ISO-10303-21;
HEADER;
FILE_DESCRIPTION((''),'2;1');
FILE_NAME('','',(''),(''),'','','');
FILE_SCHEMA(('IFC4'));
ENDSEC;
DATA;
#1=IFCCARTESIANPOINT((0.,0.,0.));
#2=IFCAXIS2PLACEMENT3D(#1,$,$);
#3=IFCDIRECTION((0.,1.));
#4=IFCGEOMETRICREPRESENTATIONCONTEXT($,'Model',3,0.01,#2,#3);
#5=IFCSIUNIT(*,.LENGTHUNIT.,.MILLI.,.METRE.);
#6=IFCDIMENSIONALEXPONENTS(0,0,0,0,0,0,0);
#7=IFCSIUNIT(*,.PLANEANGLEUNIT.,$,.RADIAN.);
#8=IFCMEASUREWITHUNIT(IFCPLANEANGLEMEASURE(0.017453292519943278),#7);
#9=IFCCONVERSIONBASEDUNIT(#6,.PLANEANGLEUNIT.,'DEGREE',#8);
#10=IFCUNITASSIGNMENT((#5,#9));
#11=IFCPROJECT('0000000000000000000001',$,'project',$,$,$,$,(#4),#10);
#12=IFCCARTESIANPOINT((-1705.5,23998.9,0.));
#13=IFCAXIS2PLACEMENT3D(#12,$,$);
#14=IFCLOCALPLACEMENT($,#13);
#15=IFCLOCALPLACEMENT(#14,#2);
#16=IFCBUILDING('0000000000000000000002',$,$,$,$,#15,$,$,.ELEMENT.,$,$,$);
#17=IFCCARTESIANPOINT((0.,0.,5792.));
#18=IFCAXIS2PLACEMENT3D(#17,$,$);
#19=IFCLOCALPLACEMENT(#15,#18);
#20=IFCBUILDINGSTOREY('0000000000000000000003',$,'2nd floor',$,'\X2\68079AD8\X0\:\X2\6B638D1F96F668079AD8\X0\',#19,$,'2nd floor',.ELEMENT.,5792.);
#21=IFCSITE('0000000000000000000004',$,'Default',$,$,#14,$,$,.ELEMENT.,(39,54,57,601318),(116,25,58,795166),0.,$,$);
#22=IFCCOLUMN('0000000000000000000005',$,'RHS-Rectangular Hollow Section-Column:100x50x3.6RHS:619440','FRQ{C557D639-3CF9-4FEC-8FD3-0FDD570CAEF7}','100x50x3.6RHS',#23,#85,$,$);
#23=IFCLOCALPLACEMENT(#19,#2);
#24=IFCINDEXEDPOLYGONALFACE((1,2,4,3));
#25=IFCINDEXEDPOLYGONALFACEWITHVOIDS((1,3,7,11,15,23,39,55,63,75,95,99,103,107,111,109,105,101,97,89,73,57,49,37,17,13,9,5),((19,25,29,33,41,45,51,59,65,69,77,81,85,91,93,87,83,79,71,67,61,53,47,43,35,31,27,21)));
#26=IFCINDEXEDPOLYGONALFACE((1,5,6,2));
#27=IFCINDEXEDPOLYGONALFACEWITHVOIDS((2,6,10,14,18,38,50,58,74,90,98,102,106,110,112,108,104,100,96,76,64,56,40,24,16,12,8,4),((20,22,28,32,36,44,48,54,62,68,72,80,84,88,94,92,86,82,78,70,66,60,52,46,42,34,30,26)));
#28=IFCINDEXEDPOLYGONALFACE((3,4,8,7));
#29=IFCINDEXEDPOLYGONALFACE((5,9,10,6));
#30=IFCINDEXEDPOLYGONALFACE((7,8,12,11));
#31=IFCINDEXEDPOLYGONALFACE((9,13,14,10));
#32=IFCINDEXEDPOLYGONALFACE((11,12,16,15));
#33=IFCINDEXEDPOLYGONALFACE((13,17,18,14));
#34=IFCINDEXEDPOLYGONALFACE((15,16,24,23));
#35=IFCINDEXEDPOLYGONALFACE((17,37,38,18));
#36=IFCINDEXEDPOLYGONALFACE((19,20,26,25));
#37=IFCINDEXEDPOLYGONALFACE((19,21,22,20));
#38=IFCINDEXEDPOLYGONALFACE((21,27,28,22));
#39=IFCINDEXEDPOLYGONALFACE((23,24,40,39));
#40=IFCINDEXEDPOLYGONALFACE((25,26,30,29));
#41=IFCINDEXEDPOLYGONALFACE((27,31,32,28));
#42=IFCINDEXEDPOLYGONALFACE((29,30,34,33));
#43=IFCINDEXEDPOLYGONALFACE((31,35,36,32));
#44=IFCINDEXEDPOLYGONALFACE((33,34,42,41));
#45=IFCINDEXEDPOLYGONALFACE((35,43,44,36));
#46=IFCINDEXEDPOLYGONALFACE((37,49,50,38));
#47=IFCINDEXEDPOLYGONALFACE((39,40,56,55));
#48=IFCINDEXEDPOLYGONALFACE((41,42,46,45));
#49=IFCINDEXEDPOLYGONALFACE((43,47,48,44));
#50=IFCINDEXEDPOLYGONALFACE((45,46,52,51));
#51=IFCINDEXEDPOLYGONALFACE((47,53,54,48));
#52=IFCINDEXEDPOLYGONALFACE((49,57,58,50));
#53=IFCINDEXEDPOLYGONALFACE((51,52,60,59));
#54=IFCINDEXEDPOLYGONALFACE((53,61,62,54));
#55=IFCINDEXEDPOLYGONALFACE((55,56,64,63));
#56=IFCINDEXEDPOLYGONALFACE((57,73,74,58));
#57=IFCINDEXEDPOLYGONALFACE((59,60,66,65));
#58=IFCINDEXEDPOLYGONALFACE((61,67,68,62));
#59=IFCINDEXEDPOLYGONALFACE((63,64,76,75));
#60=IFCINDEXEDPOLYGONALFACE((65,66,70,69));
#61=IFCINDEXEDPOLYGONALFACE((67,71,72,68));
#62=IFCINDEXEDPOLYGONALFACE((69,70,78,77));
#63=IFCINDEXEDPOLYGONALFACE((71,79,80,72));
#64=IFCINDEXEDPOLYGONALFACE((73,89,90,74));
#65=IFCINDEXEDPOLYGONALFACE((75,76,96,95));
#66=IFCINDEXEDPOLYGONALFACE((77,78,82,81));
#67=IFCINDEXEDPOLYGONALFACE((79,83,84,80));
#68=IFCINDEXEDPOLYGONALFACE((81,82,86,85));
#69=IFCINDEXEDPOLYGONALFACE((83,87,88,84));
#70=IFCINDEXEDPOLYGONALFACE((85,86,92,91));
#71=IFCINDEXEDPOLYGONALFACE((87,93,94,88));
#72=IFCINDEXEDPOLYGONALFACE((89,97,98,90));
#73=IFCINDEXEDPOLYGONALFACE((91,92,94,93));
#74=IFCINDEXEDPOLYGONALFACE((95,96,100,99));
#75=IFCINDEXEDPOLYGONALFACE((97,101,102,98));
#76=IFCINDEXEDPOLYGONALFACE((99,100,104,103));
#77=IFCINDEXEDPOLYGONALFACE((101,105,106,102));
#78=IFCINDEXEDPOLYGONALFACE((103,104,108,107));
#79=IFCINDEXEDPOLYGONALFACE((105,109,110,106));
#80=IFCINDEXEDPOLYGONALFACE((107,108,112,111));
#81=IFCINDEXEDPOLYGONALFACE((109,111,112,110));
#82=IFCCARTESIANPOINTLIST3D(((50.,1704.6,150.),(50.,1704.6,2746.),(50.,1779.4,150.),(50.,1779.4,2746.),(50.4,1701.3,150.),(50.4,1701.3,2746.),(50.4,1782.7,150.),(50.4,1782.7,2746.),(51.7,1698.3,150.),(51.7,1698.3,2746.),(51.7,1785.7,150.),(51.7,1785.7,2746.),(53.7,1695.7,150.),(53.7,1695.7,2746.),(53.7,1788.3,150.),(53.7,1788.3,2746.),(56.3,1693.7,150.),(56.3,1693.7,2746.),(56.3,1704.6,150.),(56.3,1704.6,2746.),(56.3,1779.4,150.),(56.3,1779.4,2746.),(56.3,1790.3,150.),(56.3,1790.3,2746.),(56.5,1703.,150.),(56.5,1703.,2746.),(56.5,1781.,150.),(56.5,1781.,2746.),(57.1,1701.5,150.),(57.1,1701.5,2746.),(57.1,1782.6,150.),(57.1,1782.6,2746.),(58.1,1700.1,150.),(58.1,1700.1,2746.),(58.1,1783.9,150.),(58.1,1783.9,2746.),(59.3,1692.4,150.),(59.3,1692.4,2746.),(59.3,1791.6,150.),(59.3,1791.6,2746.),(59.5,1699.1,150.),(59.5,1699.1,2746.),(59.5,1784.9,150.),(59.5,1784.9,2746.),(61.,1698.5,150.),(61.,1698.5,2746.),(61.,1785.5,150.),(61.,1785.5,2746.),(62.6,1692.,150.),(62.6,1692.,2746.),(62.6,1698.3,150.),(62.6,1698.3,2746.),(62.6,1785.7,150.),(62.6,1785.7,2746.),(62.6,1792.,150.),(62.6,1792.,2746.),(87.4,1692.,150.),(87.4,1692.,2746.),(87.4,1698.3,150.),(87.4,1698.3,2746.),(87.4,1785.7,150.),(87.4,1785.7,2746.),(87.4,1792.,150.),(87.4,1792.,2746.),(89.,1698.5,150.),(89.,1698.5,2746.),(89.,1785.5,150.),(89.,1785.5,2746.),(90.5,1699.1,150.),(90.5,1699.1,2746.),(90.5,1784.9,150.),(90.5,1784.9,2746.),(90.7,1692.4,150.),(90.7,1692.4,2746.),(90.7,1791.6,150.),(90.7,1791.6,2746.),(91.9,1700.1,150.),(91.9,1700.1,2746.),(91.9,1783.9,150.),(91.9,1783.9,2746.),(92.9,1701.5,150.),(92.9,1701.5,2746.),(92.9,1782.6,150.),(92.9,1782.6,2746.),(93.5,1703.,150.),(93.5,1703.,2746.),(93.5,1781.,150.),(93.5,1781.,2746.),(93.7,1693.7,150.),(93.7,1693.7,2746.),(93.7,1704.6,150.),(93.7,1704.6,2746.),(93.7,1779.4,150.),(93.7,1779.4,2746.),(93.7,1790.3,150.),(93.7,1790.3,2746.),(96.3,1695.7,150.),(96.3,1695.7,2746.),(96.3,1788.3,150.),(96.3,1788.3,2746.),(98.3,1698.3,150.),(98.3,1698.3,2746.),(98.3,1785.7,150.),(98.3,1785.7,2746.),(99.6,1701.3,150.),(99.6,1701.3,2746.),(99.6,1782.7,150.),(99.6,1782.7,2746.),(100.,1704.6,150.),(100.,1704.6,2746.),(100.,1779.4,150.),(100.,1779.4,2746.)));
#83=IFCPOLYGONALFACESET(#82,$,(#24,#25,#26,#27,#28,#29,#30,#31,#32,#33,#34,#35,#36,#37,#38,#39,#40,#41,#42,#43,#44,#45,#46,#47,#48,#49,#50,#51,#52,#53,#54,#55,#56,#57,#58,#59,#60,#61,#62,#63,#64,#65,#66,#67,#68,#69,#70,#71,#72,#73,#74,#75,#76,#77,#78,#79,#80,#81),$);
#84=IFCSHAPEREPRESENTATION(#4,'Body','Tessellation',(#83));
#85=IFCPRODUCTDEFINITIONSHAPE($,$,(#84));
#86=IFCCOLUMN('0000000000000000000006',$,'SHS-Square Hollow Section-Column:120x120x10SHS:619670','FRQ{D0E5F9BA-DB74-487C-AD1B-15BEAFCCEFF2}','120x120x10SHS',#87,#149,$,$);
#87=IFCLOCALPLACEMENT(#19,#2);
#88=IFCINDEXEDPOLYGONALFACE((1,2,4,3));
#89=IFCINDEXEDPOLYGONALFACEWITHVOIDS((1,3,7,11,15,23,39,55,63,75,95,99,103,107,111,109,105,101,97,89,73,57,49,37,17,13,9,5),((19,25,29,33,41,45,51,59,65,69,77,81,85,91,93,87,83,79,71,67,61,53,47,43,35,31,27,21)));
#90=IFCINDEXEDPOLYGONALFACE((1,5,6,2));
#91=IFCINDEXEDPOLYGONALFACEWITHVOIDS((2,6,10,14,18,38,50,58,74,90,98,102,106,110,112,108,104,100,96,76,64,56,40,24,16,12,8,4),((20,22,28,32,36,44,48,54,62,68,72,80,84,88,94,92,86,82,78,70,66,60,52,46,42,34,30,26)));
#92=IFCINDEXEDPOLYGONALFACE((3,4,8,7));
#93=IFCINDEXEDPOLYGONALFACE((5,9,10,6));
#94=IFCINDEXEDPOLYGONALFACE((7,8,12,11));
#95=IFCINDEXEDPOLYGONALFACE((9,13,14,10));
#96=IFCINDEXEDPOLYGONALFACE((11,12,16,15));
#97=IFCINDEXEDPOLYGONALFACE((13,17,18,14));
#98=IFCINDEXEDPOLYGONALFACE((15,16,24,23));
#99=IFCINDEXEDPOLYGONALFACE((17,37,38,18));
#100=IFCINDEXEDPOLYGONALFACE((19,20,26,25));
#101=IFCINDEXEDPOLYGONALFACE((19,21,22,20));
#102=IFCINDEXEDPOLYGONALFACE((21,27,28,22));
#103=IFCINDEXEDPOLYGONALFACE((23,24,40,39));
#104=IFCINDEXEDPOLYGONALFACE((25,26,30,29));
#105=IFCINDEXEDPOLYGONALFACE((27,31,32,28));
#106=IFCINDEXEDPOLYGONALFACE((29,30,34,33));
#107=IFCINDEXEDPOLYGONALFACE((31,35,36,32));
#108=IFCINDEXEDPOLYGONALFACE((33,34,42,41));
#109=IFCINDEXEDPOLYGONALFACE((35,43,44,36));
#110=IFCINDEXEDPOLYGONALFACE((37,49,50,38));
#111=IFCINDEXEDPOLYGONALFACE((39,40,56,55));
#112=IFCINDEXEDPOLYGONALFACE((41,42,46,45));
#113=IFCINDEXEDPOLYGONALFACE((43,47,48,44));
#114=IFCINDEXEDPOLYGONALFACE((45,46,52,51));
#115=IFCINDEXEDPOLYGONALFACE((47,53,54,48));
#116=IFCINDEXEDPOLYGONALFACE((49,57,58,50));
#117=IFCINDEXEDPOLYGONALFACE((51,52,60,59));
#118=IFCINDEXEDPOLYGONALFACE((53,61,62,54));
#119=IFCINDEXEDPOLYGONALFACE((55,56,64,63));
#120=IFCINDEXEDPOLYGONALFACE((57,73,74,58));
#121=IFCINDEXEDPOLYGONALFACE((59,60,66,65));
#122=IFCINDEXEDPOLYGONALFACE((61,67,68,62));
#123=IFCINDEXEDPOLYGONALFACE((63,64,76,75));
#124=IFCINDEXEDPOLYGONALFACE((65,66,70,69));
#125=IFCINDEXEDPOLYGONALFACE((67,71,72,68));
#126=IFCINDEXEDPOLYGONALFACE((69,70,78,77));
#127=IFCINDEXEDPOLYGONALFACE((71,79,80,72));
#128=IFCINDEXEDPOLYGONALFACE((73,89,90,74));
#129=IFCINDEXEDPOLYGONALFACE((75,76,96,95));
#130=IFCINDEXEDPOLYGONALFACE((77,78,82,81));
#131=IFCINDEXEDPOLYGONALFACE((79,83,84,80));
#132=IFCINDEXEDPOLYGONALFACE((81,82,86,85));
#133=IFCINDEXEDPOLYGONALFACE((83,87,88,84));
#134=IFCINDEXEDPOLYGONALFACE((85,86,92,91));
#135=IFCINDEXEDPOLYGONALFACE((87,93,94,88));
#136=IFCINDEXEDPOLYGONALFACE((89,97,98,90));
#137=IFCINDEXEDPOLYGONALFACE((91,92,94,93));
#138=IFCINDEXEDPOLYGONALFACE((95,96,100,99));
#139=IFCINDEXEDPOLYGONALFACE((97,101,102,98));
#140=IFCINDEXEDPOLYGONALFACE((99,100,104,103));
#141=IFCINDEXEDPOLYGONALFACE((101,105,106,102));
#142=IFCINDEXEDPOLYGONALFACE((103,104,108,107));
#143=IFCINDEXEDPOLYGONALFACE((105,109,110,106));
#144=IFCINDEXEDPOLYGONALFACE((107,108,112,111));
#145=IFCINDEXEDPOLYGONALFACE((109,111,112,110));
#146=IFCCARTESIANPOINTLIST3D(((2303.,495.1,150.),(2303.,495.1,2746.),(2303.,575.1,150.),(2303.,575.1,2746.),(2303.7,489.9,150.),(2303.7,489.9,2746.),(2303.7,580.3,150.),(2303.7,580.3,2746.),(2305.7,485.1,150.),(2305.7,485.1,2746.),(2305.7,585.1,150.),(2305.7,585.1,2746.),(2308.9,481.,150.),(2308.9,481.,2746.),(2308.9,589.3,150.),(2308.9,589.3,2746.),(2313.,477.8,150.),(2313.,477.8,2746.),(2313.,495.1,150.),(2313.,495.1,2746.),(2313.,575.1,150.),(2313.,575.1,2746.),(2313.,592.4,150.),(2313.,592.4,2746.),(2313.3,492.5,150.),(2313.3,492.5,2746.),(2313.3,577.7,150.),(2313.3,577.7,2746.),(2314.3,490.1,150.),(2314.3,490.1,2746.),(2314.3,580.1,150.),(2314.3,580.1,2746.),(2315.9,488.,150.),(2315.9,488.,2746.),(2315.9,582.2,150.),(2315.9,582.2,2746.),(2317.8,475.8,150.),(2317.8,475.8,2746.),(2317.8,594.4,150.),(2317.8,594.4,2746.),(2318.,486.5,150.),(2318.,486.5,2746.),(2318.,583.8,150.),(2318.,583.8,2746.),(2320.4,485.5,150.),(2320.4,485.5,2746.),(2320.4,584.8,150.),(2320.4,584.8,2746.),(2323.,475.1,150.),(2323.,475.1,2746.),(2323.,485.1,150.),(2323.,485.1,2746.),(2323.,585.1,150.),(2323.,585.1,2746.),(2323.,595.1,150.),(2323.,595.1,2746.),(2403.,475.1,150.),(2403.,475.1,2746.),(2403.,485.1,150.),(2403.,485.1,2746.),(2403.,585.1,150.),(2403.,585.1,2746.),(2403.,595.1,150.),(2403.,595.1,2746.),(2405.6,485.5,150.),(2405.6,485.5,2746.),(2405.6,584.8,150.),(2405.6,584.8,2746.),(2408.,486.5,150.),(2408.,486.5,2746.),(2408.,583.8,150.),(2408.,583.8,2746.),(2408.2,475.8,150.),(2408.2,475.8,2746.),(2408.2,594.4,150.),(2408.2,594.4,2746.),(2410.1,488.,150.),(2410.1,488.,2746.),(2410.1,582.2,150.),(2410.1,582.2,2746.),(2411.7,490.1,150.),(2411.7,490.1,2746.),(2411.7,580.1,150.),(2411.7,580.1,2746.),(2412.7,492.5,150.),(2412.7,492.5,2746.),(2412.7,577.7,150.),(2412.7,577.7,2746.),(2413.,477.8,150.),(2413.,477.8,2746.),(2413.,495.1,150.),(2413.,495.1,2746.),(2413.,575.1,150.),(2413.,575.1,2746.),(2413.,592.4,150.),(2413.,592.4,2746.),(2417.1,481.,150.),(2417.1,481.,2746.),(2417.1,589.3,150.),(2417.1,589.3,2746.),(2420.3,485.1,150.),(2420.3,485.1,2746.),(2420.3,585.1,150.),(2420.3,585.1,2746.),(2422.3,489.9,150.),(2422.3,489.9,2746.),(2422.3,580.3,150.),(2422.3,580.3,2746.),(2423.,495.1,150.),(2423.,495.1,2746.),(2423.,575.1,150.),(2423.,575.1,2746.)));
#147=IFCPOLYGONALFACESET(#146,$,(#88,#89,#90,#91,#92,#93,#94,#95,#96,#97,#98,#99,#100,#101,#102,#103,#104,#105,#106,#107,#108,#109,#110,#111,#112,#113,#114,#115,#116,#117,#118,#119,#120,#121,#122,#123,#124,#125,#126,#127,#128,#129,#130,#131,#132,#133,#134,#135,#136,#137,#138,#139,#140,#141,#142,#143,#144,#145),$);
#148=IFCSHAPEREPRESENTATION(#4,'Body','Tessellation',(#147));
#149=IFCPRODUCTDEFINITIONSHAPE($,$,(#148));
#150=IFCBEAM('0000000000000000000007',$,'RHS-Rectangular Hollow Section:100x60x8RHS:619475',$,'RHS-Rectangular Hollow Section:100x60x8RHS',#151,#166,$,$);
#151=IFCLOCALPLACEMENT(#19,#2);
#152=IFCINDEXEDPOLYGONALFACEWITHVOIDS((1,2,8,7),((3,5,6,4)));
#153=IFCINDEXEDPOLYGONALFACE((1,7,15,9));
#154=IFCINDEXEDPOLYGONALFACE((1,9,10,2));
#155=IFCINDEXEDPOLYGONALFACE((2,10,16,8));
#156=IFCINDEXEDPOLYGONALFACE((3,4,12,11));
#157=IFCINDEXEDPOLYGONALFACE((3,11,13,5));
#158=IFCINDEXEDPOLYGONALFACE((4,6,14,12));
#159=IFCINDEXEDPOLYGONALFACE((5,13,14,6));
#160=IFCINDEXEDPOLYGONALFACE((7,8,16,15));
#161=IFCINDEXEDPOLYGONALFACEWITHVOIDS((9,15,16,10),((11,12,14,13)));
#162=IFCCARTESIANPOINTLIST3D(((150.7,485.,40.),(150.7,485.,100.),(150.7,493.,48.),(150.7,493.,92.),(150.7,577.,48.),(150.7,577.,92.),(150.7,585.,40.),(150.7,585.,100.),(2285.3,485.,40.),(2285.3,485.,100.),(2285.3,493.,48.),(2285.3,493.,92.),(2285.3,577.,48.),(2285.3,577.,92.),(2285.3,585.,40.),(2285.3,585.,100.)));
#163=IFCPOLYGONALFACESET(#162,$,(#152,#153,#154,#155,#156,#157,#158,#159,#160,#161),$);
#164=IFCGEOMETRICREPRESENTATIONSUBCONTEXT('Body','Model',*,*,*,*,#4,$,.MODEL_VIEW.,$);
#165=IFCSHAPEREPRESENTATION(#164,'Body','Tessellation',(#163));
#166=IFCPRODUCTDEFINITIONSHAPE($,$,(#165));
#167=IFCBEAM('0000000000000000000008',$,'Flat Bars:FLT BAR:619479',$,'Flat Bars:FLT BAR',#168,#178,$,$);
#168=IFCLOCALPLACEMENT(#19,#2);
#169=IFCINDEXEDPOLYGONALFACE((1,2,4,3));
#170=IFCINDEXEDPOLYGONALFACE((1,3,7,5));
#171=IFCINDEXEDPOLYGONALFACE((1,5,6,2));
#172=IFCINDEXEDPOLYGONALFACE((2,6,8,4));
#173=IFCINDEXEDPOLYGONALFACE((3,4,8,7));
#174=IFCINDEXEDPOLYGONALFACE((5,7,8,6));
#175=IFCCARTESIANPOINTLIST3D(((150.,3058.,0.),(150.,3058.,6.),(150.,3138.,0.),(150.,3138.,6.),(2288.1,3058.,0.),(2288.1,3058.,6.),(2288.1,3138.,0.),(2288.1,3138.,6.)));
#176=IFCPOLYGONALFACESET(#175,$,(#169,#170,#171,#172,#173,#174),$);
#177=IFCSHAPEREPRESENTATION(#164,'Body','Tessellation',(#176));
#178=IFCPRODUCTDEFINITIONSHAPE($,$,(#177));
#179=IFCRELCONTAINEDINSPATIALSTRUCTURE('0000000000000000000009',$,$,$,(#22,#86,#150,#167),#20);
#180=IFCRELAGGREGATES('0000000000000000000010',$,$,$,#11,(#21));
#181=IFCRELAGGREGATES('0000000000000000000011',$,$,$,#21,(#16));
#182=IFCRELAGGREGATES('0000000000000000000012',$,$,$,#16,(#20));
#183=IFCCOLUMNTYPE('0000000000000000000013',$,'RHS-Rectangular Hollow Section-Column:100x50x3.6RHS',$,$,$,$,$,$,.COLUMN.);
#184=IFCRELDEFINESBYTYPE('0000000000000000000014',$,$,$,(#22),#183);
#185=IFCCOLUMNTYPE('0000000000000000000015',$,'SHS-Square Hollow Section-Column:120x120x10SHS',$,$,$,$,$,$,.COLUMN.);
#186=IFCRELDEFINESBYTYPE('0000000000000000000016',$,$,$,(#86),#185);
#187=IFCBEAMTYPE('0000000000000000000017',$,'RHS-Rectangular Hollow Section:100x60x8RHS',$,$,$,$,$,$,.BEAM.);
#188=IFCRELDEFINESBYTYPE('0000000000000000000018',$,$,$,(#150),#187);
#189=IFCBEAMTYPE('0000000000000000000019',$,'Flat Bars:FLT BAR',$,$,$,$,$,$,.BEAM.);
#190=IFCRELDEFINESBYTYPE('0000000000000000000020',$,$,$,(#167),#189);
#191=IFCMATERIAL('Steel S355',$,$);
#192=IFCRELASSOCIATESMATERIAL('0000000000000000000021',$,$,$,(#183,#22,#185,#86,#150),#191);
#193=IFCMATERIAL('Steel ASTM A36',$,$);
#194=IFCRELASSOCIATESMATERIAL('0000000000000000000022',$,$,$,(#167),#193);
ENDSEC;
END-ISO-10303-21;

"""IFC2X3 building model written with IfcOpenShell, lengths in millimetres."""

from ifc_helpers import new_model, entity, si_unit, converted_unit, point, direction, frame, frame_2d, origin, origin_2d, origin_2d_with_axis, place, context, subcontext, project, spatial, circle_curve, line_curve, trimmed, segment, composite_curve, rectangle, hollow_rectangle, outline, extrude, boolean, clip, halfspace, material, type_object, element, save


model = new_model("IFC2X3")

# Units and contexts
model_context = context("Model", 3, precision=0.01, world=origin(), true_north=direction((0.0, 1.0)))
body_context = subcontext(model_context, "Body", "Model", "MODEL_VIEW")
ifc_project = project(units=[si_unit("LENGTHUNIT", "METRE", prefix="MILLI"), converted_unit("PLANEANGLEUNIT", "DEGREE", entity("IfcPlaneAngleMeasure", 0.017453292519943278), si_unit("PLANEANGLEUNIT", "RADIAN"), dimensions=[0, 0, 0, 0, 0, 0, 0])], contexts=[model_context])

# Site, building, storey
site_placement = place(None, frame((-1705.5, 23998.9, 0.0)))
site = spatial("IfcSite", under=ifc_project, at=site_placement, Name="Default", CompositionType="ELEMENT", RefLatitude=(39, 54, 57, 601318), RefLongitude=(116, 25, 58, 795166), RefElevation=0.0)
building_placement = place(site_placement, origin())
building = spatial("IfcBuilding", under=site, at=building_placement, CompositionType="ELEMENT")
storey_placement = place(building_placement, frame((0.0, 0.0, 5792.0)))
storey = spatial("IfcBuildingStorey", under=building, at=storey_placement, Name="2nd floor", ObjectType="标高:正负零标高", LongName="2nd floor", CompositionType="ELEMENT", Elevation=5792.0)

# Shared definitions
ifc_material_1 = material(Name="Steel S355")

# Shared definitions
column_type_1 = type_object("IfcColumnType", Name="RHS-Rectangular Hollow Section-Column:100x50x3.6RHS", PredefinedType="COLUMN", material=ifc_material_1)

# Column, opening
column_1_placement = place(storey_placement, frame((75.0, 1742.0, 2876.9)))
column_1 = element("IfcColumn", 1, at=column_1_placement, inside=storey, type_object=column_type_1, material=ifc_material_1, Name="RHS-Rectangular Hollow Section-Column:100x50x3.6RHS:619440", Description="FRQ{C557D639-3CF9-4FEC-8FD3-0FDD570CAEF7}", ObjectType="100x50x3.6RHS", context=model_context, shape_type="Clipping", body=[
    clip(clip(extrude(hollow_rectangle(XDim=50.0, YDim=100.0, WallThickness=6.3, InnerFilletRadius=6.3, OuterFilletRadius=12.6, at=origin_2d()), origin(), (0.0, 0.0, -1.0), 2782.8), halfspace(frame((-75.0, -1742.0, -2726.9), z_axis=(0.0, 0.0, 1.0), x_axis=(1.0, 0.0, 0.0)), True)), halfspace(frame((-75.0, -1742.0, -55.9), z_axis=(0.0, 0.0, -1.0), x_axis=(-1.0, 0.0, 0.0)), True)),
])
opening_1_placement = place(column_1_placement, frame((0.0, -150.1, -130.9), z_axis=(0.0, 1.0, 0.0), x_axis=(-1.0, 0.0, 0.0)))
element("IfcOpeningElement", 2, at=opening_1_placement, cuts=column_1, ObjectType="Opening", context=model_context, shape_type="SweptSolid", body=[
    extrude(outline(composite_curve([segment(trimmed(circle_curve(frame_2d((43.0, 32.0), x_axis=(1.0, 0.0)), 32.0), [point((43.0, 0.0))], [point((75.0, 32.0))], True, "CARTESIAN"), True, "CONTINUOUS"), segment(trimmed(line_curve((75.0, 32.0), (0.0, 1.0), 86.0), [point((75.0, 32.0))], [point((75.0, 118.0))], True, "CARTESIAN"), True, "CONTINUOUS"), segment(trimmed(circle_curve(frame_2d((43.0, 118.0), x_axis=(1.0, 0.0)), 32.0), [point((75.0, 118.0))], [point((43.0, 150.0))], True, "CARTESIAN"), True, "CONTINUOUS"), segment(trimmed(line_curve((43.0, 150.0), (-1.0, 0.0), 86.0), [point((43.0, 150.0))], [point((-43.0, 150.0))], True, "CARTESIAN"), True, "CONTINUOUS"), segment(trimmed(circle_curve(frame_2d((-43.0, 118.0), x_axis=(1.0, 0.0)), 32.0), [point((-43.0, 150.0))], [point((-75.0, 118.0))], True, "CARTESIAN"), True, "CONTINUOUS"), segment(trimmed(line_curve((-75.0, 118.0), (0.0, -1.0), 86.0), [point((-75.0, 118.0))], [point((-75.0, 32.0))], True, "CARTESIAN"), True, "CONTINUOUS"), segment(trimmed(circle_curve(frame_2d((-43.0, 32.0), x_axis=(1.0, 0.0)), 32.0), [point((-75.0, 32.0))], [point((-43.0, 0.0))], True, "CARTESIAN"), True, "CONTINUOUS"), segment(trimmed(line_curve((-43.0, 0.0), (1.0, 0.0), 86.0), [point((-43.0, 0.0))], [point((43.0, 0.0))], True, "CARTESIAN"), True, "CONTINUOUS")], self_intersect="UNKNOWN")), origin(), (0.0, 0.0, 1.0), 300.2),
])

# Column
column_type_2 = type_object("IfcColumnType", Name="SHS-Square Hollow Section-Column:120x120x10SHS", PredefinedType="COLUMN", material=ifc_material_1)
column_2_placement = place(storey_placement, frame((2363.0, 535.1, 2830.9), z_axis=(0.0, 0.0, 1.0), x_axis=(0.0, 1.0, 0.0)))
element("IfcColumn", 3, at=column_2_placement, inside=storey, type_object=column_type_2, material=ifc_material_1, Name="SHS-Square Hollow Section-Column:120x120x10SHS:619670", Description="FRQ{D0E5F9BA-DB74-487C-AD1B-15BEAFCCEFF2}", ObjectType="120x120x10SHS", context=model_context, shape_type="Clipping", body=[
    clip(clip(extrude(hollow_rectangle(XDim=120.0, YDim=120.0, WallThickness=10.0, InnerFilletRadius=10.0, OuterFilletRadius=20.0, at=origin_2d()), origin(), (0.0, 0.0, -1.0), 2765.7), halfspace(frame((-535.1, 2363.0, -2680.9), z_axis=(0.0, 0.0, 1.0), x_axis=(0.0, -1.0, 0.0)), True)), halfspace(frame((-535.1, 2363.0, -84.9), z_axis=(0.0, 0.0, -1.0), x_axis=(0.0, 1.0, 0.0)), True)),
])

# Beams
beam_type_1 = type_object("IfcBeamType", Name="RHS-Rectangular Hollow Section:100x60x8RHS", PredefinedType="BEAM")
beam_1_placement = place(storey_placement, frame((150.7, 585.0, 70.0)))
element("IfcBeam", 4, at=beam_1_placement, inside=storey, type_object=beam_type_1, material=ifc_material_1, Name="RHS-Rectangular Hollow Section:100x60x8RHS:619475", ObjectType="RHS-Rectangular Hollow Section:100x60x8RHS", context=body_context, shape_type="SweptSolid", body=[
    boolean("DIFFERENCE", extrude(rectangle(XDim=60.0, YDim=100.0, at=frame_2d((0.0, 0.0), x_axis=(1.0, 0.0))), frame((0.0, -50.0, 0.0), z_axis=(1.0, 0.0, 0.0), x_axis=(0.0, 0.0, -1.0)), (0.0, 0.0, 1.0), 2134.6), extrude(rectangle(XDim=44.0, YDim=84.0, at=frame_2d((0.0, 0.0), x_axis=(0.0, 1.0))), frame((2134.6, -50.0, 0.0), z_axis=(-1.0, 0.0, 0.0), x_axis=(0.0, 1.0, 0.0)), (0.0, 0.0, 1.0), 2134.6)),
])
ifc_material_2 = material(Name="Steel ASTM A36")
beam_type_2 = type_object("IfcBeamType", Name="Flat Bars:FLT BAR", PredefinedType="BEAM")
beam_2_placement = place(storey_placement, frame((150.0, 3098.0, 6.0)))
element("IfcBeam", 5, at=beam_2_placement, inside=storey, type_object=beam_type_2, material=ifc_material_2, Name="Flat Bars:FLT BAR:619479", ObjectType="Flat Bars:FLT BAR", context=body_context, shape_type="SweptSolid", body=[
    extrude(rectangle(XDim=6.0, YDim=80.0, at=origin_2d_with_axis()), frame((0.0, 0.0, -3.0), z_axis=(1.0, 0.0, 0.0), x_axis=(0.0, 0.0, -1.0)), (0.0, 0.0, 1.0), 2138.1),
])

save(model, "model.ifc")
